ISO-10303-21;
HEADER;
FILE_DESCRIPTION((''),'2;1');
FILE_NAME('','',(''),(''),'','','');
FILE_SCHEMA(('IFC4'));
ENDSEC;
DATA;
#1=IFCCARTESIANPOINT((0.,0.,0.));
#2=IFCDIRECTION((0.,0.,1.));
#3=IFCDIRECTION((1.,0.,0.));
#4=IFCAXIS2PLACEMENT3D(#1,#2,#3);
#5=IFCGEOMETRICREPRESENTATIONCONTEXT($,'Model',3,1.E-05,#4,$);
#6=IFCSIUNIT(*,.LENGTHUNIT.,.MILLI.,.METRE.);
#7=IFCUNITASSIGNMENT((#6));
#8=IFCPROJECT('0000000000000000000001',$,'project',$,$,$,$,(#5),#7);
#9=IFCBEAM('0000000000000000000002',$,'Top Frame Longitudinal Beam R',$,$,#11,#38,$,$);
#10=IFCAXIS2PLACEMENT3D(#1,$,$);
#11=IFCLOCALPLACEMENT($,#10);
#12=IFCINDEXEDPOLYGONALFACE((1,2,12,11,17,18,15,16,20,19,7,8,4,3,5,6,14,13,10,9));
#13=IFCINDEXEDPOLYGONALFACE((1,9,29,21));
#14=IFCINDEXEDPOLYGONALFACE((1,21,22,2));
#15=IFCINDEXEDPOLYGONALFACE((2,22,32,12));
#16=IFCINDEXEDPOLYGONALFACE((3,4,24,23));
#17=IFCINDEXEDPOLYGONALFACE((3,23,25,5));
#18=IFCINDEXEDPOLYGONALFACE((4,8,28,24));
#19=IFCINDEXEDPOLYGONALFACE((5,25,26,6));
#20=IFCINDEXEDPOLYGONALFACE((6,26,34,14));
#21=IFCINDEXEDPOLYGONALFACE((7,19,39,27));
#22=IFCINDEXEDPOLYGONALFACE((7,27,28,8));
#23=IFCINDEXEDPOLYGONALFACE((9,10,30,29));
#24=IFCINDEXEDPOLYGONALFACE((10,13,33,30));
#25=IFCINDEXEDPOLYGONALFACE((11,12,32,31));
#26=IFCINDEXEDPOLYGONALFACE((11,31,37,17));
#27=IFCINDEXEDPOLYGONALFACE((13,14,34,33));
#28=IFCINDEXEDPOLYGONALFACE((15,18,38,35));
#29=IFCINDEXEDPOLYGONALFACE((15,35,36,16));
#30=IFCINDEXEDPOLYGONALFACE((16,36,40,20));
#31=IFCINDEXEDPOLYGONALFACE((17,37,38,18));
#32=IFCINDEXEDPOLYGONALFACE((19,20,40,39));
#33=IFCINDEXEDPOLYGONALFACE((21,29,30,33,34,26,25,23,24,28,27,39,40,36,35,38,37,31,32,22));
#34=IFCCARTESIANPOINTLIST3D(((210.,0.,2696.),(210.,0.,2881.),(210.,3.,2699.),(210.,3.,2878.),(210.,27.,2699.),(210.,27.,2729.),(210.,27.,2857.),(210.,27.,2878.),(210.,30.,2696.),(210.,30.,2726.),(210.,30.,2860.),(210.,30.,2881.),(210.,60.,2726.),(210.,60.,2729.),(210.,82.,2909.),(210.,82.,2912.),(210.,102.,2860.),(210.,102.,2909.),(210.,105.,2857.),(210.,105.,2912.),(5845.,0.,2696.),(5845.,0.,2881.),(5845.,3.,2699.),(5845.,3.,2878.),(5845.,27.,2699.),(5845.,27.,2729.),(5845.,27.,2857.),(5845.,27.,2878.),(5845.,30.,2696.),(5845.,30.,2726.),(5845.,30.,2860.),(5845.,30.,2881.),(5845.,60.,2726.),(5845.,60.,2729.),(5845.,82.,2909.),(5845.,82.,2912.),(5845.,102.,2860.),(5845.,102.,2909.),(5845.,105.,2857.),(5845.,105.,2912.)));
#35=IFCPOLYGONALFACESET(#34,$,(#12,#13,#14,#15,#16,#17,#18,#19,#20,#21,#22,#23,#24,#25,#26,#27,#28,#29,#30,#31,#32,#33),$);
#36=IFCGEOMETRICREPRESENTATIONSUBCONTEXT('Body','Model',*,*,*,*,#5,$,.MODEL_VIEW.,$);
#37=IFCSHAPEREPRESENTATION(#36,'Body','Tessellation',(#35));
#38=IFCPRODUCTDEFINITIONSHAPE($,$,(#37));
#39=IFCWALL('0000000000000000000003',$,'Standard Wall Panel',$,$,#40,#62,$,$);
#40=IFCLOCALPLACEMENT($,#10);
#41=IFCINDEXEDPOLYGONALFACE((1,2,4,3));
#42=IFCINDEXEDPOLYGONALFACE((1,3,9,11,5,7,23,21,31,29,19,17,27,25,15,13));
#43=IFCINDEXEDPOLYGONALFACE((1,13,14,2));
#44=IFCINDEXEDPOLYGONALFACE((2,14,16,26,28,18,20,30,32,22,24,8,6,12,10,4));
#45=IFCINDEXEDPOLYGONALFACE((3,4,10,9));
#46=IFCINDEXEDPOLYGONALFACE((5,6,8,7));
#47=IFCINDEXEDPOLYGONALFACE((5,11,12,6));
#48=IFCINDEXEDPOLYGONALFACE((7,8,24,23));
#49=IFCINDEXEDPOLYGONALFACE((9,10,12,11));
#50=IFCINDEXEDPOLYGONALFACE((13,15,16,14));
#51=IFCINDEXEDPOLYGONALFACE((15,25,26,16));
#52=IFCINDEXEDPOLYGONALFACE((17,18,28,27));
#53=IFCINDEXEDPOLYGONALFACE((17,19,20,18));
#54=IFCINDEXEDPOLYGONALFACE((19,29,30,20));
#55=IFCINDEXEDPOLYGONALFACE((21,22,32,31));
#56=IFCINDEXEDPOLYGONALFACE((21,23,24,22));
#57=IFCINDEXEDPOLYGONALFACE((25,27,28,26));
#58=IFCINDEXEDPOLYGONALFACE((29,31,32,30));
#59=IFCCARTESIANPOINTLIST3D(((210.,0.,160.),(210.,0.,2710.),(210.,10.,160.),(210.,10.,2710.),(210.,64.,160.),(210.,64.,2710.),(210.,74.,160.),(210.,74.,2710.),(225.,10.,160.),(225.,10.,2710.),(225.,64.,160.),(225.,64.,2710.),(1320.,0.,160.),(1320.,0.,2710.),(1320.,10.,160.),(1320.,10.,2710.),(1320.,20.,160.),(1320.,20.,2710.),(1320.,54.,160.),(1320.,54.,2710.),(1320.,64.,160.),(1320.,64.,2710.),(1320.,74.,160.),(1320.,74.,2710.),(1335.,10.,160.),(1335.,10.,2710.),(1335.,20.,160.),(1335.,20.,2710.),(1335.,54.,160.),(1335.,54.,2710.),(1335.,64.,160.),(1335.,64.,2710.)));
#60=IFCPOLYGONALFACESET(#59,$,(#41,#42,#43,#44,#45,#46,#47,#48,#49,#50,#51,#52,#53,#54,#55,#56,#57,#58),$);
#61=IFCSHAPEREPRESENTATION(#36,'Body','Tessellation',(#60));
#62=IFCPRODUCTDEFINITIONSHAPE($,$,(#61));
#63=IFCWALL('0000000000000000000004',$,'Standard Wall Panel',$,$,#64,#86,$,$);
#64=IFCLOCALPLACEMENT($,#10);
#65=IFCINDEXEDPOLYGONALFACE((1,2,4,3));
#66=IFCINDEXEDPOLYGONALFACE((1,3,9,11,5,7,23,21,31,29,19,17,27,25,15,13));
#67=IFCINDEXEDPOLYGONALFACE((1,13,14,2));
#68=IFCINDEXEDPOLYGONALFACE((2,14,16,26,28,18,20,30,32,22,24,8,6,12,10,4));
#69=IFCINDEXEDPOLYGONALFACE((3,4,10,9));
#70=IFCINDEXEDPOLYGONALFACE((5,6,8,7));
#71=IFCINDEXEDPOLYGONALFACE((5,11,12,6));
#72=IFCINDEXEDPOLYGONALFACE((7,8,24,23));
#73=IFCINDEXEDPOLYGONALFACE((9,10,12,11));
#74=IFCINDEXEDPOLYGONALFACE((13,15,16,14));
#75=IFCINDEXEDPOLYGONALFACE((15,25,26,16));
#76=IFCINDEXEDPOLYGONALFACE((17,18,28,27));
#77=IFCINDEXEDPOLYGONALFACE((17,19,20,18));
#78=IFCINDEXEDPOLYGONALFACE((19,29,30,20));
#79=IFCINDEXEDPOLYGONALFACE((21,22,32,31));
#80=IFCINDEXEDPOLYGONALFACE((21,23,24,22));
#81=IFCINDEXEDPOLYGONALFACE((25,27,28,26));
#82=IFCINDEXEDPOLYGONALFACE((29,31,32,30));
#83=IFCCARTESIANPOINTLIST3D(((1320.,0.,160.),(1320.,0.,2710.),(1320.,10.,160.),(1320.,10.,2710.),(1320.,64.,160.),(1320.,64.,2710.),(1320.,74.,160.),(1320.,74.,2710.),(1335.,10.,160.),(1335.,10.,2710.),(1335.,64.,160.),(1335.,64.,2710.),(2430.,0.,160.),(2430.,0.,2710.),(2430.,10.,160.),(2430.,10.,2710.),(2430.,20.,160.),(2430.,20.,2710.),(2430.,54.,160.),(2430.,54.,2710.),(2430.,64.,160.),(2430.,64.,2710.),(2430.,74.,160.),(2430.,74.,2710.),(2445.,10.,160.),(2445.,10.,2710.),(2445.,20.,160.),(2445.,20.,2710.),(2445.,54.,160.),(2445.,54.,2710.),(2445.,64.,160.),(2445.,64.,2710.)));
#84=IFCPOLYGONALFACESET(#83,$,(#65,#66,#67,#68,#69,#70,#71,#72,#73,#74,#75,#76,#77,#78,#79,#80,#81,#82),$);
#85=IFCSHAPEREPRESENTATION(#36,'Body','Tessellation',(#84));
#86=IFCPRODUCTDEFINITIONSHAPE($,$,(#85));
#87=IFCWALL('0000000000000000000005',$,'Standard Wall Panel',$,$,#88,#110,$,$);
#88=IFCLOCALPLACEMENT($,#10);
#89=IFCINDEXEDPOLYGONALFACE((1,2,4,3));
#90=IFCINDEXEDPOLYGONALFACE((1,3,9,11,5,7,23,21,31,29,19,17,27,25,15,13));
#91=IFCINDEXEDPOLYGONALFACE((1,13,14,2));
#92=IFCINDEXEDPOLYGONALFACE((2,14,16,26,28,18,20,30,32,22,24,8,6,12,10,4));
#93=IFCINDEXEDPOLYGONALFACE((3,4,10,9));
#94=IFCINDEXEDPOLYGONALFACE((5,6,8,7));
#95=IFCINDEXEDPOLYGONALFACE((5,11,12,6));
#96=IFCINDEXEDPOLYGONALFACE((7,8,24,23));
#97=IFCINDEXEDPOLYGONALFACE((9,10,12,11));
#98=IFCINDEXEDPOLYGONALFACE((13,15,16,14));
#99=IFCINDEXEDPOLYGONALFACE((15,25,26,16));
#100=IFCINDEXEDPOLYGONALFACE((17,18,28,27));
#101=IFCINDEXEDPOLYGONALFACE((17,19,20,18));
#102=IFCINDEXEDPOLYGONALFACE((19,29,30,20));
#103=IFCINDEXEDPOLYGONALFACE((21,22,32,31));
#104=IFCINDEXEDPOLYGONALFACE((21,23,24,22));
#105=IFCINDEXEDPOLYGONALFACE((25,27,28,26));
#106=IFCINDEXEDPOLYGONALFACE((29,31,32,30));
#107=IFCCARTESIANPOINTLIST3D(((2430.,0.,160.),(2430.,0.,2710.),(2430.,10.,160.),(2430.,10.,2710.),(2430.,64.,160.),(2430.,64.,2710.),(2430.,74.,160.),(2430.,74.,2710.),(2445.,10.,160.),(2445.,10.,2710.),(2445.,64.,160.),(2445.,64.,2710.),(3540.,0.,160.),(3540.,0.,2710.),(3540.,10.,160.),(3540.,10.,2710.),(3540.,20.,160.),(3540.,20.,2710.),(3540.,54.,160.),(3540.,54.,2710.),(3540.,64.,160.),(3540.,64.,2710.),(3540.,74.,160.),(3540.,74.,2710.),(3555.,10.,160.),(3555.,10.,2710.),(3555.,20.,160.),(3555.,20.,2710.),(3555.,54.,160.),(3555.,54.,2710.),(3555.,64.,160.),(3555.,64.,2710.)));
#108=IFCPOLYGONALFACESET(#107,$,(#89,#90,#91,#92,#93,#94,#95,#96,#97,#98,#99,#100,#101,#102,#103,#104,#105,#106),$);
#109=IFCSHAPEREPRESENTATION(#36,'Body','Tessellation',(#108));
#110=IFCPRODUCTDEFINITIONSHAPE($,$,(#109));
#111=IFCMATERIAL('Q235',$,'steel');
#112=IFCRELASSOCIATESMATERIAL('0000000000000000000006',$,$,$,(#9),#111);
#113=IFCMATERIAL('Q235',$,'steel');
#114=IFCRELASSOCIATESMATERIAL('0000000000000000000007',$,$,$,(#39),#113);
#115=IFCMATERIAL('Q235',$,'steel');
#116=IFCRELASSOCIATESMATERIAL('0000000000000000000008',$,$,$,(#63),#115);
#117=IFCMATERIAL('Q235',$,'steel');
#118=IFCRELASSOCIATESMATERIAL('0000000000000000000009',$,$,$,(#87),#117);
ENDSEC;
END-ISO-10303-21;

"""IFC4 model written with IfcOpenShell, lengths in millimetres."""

from ifc_helpers import new_model, si_unit, frame, origin_with_axes, place, context, subcontext, project, line, indexed_curve, outline, extrude, material, element, save


model = new_model("IFC4")

# Units and contexts
model_context = context("Model", 3, precision=1e-05, world=origin_with_axes())
body_context = subcontext(model_context, "Body", "Model", "MODEL_VIEW")
ifc_project = project(units=[si_unit("LENGTHUNIT", "METRE", prefix="MILLI")], contexts=[model_context])

# Beam
ifc_material_1 = material(Name="Q235", Category="steel")
beam_1_placement = place(None, frame((210.0, 0.0, 2696.0), z_axis=(1.0, 0.0, 0.0), x_axis=(0.0, 1.0, 0.0)))
element("IfcBeam", 1, at=beam_1_placement, material=ifc_material_1, Name="Top Frame Longitudinal Beam R", context=body_context, shape_type="SweptSolid", body=[
    extrude(outline(indexed_curve([(60.0, 30.0), (30.0, 30.0), (30.0, 0.0), (0.0, 0.0), (0.0, 185.0), (30.0, 185.0), (30.0, 164.0), (102.0, 164.0), (102.0, 213.0), (82.0, 213.0), (82.0, 216.0), (105.0, 216.0), (105.0, 161.0), (27.0, 161.0), (27.0, 182.0), (3.0, 182.0), (3.0, 3.0), (27.0, 3.0), (27.0, 33.0), (60.0, 33.0), (60.0, 30.0)], segments=[line(1, 2, 3, 4, 5, 6, 7, 8, 9, 10, 11, 12, 13, 14, 15, 16, 17, 18, 19, 20, 21, 1)])), origin_with_axes(), (0.0, 0.0, 1.0), 5635.0),
])

# Walls
ifc_material_2 = material(Name="Q235", Category="steel")
wall_1_placement = place(None, frame((210.0, 0.0, 160.0), z_axis=(0.0, 0.0, 1.0), x_axis=(1.0, 0.0, 0.0)))
element("IfcWall", 2, at=wall_1_placement, material=ifc_material_2, Name="Standard Wall Panel", context=body_context, shape_type="SweptSolid", body=[
    extrude(outline(indexed_curve([(0.0, 0.0), (0.0, 10.0), (15.0, 10.0), (15.0, 64.0), (0.0, 64.0), (0.0, 74.0), (1110.0, 74.0), (1110.0, 64.0), (1125.0, 64.0), (1125.0, 54.0), (1125.0, 54.0), (1110.0, 54.0), (1110.0, 20.0), (1125.0, 20.0), (1125.0, 10.0), (1110.0, 10.0), (1110.0, 0.0), (0.0, 0.0)], segments=[line(1, 2, 3, 4, 5, 6, 7, 8, 9, 10, 11, 12, 13, 14, 15, 16, 17, 18, 1)])), origin_with_axes(), (0.0, 0.0, 1.0), 2550.0),
])
ifc_material_3 = material(Name="Q235", Category="steel")
wall_2_placement = place(None, frame((1320.0, 0.0, 160.0), z_axis=(0.0, 0.0, 1.0), x_axis=(1.0, 0.0, 0.0)))
element("IfcWall", 3, at=wall_2_placement, material=ifc_material_3, Name="Standard Wall Panel", context=body_context, shape_type="SweptSolid", body=[
    extrude(outline(indexed_curve([(0.0, 0.0), (0.0, 10.0), (15.0, 10.0), (15.0, 64.0), (0.0, 64.0), (0.0, 74.0), (1110.0, 74.0), (1110.0, 64.0), (1125.0, 64.0), (1125.0, 54.0), (1125.0, 54.0), (1110.0, 54.0), (1110.0, 20.0), (1125.0, 20.0), (1125.0, 10.0), (1110.0, 10.0), (1110.0, 0.0), (0.0, 0.0)], segments=[line(1, 2, 3, 4, 5, 6, 7, 8, 9, 10, 11, 12, 13, 14, 15, 16, 17, 18, 1)])), origin_with_axes(), (0.0, 0.0, 1.0), 2550.0),
])
ifc_material_4 = material(Name="Q235", Category="steel")
wall_3_placement = place(None, frame((2430.0, 0.0, 160.0), z_axis=(0.0, 0.0, 1.0), x_axis=(1.0, 0.0, 0.0)))
element("IfcWall", 4, at=wall_3_placement, material=ifc_material_4, Name="Standard Wall Panel", context=body_context, shape_type="SweptSolid", body=[
    extrude(outline(indexed_curve([(0.0, 0.0), (0.0, 10.0), (15.0, 10.0), (15.0, 64.0), (0.0, 64.0), (0.0, 74.0), (1110.0, 74.0), (1110.0, 64.0), (1125.0, 64.0), (1125.0, 54.0), (1125.0, 54.0), (1110.0, 54.0), (1110.0, 20.0), (1125.0, 20.0), (1125.0, 10.0), (1110.0, 10.0), (1110.0, 0.0), (0.0, 0.0)], segments=[line(1, 2, 3, 4, 5, 6, 7, 8, 9, 10, 11, 12, 13, 14, 15, 16, 17, 18, 1)])), origin_with_axes(), (0.0, 0.0, 1.0), 2550.0),
])

save(model, "model.ifc")
